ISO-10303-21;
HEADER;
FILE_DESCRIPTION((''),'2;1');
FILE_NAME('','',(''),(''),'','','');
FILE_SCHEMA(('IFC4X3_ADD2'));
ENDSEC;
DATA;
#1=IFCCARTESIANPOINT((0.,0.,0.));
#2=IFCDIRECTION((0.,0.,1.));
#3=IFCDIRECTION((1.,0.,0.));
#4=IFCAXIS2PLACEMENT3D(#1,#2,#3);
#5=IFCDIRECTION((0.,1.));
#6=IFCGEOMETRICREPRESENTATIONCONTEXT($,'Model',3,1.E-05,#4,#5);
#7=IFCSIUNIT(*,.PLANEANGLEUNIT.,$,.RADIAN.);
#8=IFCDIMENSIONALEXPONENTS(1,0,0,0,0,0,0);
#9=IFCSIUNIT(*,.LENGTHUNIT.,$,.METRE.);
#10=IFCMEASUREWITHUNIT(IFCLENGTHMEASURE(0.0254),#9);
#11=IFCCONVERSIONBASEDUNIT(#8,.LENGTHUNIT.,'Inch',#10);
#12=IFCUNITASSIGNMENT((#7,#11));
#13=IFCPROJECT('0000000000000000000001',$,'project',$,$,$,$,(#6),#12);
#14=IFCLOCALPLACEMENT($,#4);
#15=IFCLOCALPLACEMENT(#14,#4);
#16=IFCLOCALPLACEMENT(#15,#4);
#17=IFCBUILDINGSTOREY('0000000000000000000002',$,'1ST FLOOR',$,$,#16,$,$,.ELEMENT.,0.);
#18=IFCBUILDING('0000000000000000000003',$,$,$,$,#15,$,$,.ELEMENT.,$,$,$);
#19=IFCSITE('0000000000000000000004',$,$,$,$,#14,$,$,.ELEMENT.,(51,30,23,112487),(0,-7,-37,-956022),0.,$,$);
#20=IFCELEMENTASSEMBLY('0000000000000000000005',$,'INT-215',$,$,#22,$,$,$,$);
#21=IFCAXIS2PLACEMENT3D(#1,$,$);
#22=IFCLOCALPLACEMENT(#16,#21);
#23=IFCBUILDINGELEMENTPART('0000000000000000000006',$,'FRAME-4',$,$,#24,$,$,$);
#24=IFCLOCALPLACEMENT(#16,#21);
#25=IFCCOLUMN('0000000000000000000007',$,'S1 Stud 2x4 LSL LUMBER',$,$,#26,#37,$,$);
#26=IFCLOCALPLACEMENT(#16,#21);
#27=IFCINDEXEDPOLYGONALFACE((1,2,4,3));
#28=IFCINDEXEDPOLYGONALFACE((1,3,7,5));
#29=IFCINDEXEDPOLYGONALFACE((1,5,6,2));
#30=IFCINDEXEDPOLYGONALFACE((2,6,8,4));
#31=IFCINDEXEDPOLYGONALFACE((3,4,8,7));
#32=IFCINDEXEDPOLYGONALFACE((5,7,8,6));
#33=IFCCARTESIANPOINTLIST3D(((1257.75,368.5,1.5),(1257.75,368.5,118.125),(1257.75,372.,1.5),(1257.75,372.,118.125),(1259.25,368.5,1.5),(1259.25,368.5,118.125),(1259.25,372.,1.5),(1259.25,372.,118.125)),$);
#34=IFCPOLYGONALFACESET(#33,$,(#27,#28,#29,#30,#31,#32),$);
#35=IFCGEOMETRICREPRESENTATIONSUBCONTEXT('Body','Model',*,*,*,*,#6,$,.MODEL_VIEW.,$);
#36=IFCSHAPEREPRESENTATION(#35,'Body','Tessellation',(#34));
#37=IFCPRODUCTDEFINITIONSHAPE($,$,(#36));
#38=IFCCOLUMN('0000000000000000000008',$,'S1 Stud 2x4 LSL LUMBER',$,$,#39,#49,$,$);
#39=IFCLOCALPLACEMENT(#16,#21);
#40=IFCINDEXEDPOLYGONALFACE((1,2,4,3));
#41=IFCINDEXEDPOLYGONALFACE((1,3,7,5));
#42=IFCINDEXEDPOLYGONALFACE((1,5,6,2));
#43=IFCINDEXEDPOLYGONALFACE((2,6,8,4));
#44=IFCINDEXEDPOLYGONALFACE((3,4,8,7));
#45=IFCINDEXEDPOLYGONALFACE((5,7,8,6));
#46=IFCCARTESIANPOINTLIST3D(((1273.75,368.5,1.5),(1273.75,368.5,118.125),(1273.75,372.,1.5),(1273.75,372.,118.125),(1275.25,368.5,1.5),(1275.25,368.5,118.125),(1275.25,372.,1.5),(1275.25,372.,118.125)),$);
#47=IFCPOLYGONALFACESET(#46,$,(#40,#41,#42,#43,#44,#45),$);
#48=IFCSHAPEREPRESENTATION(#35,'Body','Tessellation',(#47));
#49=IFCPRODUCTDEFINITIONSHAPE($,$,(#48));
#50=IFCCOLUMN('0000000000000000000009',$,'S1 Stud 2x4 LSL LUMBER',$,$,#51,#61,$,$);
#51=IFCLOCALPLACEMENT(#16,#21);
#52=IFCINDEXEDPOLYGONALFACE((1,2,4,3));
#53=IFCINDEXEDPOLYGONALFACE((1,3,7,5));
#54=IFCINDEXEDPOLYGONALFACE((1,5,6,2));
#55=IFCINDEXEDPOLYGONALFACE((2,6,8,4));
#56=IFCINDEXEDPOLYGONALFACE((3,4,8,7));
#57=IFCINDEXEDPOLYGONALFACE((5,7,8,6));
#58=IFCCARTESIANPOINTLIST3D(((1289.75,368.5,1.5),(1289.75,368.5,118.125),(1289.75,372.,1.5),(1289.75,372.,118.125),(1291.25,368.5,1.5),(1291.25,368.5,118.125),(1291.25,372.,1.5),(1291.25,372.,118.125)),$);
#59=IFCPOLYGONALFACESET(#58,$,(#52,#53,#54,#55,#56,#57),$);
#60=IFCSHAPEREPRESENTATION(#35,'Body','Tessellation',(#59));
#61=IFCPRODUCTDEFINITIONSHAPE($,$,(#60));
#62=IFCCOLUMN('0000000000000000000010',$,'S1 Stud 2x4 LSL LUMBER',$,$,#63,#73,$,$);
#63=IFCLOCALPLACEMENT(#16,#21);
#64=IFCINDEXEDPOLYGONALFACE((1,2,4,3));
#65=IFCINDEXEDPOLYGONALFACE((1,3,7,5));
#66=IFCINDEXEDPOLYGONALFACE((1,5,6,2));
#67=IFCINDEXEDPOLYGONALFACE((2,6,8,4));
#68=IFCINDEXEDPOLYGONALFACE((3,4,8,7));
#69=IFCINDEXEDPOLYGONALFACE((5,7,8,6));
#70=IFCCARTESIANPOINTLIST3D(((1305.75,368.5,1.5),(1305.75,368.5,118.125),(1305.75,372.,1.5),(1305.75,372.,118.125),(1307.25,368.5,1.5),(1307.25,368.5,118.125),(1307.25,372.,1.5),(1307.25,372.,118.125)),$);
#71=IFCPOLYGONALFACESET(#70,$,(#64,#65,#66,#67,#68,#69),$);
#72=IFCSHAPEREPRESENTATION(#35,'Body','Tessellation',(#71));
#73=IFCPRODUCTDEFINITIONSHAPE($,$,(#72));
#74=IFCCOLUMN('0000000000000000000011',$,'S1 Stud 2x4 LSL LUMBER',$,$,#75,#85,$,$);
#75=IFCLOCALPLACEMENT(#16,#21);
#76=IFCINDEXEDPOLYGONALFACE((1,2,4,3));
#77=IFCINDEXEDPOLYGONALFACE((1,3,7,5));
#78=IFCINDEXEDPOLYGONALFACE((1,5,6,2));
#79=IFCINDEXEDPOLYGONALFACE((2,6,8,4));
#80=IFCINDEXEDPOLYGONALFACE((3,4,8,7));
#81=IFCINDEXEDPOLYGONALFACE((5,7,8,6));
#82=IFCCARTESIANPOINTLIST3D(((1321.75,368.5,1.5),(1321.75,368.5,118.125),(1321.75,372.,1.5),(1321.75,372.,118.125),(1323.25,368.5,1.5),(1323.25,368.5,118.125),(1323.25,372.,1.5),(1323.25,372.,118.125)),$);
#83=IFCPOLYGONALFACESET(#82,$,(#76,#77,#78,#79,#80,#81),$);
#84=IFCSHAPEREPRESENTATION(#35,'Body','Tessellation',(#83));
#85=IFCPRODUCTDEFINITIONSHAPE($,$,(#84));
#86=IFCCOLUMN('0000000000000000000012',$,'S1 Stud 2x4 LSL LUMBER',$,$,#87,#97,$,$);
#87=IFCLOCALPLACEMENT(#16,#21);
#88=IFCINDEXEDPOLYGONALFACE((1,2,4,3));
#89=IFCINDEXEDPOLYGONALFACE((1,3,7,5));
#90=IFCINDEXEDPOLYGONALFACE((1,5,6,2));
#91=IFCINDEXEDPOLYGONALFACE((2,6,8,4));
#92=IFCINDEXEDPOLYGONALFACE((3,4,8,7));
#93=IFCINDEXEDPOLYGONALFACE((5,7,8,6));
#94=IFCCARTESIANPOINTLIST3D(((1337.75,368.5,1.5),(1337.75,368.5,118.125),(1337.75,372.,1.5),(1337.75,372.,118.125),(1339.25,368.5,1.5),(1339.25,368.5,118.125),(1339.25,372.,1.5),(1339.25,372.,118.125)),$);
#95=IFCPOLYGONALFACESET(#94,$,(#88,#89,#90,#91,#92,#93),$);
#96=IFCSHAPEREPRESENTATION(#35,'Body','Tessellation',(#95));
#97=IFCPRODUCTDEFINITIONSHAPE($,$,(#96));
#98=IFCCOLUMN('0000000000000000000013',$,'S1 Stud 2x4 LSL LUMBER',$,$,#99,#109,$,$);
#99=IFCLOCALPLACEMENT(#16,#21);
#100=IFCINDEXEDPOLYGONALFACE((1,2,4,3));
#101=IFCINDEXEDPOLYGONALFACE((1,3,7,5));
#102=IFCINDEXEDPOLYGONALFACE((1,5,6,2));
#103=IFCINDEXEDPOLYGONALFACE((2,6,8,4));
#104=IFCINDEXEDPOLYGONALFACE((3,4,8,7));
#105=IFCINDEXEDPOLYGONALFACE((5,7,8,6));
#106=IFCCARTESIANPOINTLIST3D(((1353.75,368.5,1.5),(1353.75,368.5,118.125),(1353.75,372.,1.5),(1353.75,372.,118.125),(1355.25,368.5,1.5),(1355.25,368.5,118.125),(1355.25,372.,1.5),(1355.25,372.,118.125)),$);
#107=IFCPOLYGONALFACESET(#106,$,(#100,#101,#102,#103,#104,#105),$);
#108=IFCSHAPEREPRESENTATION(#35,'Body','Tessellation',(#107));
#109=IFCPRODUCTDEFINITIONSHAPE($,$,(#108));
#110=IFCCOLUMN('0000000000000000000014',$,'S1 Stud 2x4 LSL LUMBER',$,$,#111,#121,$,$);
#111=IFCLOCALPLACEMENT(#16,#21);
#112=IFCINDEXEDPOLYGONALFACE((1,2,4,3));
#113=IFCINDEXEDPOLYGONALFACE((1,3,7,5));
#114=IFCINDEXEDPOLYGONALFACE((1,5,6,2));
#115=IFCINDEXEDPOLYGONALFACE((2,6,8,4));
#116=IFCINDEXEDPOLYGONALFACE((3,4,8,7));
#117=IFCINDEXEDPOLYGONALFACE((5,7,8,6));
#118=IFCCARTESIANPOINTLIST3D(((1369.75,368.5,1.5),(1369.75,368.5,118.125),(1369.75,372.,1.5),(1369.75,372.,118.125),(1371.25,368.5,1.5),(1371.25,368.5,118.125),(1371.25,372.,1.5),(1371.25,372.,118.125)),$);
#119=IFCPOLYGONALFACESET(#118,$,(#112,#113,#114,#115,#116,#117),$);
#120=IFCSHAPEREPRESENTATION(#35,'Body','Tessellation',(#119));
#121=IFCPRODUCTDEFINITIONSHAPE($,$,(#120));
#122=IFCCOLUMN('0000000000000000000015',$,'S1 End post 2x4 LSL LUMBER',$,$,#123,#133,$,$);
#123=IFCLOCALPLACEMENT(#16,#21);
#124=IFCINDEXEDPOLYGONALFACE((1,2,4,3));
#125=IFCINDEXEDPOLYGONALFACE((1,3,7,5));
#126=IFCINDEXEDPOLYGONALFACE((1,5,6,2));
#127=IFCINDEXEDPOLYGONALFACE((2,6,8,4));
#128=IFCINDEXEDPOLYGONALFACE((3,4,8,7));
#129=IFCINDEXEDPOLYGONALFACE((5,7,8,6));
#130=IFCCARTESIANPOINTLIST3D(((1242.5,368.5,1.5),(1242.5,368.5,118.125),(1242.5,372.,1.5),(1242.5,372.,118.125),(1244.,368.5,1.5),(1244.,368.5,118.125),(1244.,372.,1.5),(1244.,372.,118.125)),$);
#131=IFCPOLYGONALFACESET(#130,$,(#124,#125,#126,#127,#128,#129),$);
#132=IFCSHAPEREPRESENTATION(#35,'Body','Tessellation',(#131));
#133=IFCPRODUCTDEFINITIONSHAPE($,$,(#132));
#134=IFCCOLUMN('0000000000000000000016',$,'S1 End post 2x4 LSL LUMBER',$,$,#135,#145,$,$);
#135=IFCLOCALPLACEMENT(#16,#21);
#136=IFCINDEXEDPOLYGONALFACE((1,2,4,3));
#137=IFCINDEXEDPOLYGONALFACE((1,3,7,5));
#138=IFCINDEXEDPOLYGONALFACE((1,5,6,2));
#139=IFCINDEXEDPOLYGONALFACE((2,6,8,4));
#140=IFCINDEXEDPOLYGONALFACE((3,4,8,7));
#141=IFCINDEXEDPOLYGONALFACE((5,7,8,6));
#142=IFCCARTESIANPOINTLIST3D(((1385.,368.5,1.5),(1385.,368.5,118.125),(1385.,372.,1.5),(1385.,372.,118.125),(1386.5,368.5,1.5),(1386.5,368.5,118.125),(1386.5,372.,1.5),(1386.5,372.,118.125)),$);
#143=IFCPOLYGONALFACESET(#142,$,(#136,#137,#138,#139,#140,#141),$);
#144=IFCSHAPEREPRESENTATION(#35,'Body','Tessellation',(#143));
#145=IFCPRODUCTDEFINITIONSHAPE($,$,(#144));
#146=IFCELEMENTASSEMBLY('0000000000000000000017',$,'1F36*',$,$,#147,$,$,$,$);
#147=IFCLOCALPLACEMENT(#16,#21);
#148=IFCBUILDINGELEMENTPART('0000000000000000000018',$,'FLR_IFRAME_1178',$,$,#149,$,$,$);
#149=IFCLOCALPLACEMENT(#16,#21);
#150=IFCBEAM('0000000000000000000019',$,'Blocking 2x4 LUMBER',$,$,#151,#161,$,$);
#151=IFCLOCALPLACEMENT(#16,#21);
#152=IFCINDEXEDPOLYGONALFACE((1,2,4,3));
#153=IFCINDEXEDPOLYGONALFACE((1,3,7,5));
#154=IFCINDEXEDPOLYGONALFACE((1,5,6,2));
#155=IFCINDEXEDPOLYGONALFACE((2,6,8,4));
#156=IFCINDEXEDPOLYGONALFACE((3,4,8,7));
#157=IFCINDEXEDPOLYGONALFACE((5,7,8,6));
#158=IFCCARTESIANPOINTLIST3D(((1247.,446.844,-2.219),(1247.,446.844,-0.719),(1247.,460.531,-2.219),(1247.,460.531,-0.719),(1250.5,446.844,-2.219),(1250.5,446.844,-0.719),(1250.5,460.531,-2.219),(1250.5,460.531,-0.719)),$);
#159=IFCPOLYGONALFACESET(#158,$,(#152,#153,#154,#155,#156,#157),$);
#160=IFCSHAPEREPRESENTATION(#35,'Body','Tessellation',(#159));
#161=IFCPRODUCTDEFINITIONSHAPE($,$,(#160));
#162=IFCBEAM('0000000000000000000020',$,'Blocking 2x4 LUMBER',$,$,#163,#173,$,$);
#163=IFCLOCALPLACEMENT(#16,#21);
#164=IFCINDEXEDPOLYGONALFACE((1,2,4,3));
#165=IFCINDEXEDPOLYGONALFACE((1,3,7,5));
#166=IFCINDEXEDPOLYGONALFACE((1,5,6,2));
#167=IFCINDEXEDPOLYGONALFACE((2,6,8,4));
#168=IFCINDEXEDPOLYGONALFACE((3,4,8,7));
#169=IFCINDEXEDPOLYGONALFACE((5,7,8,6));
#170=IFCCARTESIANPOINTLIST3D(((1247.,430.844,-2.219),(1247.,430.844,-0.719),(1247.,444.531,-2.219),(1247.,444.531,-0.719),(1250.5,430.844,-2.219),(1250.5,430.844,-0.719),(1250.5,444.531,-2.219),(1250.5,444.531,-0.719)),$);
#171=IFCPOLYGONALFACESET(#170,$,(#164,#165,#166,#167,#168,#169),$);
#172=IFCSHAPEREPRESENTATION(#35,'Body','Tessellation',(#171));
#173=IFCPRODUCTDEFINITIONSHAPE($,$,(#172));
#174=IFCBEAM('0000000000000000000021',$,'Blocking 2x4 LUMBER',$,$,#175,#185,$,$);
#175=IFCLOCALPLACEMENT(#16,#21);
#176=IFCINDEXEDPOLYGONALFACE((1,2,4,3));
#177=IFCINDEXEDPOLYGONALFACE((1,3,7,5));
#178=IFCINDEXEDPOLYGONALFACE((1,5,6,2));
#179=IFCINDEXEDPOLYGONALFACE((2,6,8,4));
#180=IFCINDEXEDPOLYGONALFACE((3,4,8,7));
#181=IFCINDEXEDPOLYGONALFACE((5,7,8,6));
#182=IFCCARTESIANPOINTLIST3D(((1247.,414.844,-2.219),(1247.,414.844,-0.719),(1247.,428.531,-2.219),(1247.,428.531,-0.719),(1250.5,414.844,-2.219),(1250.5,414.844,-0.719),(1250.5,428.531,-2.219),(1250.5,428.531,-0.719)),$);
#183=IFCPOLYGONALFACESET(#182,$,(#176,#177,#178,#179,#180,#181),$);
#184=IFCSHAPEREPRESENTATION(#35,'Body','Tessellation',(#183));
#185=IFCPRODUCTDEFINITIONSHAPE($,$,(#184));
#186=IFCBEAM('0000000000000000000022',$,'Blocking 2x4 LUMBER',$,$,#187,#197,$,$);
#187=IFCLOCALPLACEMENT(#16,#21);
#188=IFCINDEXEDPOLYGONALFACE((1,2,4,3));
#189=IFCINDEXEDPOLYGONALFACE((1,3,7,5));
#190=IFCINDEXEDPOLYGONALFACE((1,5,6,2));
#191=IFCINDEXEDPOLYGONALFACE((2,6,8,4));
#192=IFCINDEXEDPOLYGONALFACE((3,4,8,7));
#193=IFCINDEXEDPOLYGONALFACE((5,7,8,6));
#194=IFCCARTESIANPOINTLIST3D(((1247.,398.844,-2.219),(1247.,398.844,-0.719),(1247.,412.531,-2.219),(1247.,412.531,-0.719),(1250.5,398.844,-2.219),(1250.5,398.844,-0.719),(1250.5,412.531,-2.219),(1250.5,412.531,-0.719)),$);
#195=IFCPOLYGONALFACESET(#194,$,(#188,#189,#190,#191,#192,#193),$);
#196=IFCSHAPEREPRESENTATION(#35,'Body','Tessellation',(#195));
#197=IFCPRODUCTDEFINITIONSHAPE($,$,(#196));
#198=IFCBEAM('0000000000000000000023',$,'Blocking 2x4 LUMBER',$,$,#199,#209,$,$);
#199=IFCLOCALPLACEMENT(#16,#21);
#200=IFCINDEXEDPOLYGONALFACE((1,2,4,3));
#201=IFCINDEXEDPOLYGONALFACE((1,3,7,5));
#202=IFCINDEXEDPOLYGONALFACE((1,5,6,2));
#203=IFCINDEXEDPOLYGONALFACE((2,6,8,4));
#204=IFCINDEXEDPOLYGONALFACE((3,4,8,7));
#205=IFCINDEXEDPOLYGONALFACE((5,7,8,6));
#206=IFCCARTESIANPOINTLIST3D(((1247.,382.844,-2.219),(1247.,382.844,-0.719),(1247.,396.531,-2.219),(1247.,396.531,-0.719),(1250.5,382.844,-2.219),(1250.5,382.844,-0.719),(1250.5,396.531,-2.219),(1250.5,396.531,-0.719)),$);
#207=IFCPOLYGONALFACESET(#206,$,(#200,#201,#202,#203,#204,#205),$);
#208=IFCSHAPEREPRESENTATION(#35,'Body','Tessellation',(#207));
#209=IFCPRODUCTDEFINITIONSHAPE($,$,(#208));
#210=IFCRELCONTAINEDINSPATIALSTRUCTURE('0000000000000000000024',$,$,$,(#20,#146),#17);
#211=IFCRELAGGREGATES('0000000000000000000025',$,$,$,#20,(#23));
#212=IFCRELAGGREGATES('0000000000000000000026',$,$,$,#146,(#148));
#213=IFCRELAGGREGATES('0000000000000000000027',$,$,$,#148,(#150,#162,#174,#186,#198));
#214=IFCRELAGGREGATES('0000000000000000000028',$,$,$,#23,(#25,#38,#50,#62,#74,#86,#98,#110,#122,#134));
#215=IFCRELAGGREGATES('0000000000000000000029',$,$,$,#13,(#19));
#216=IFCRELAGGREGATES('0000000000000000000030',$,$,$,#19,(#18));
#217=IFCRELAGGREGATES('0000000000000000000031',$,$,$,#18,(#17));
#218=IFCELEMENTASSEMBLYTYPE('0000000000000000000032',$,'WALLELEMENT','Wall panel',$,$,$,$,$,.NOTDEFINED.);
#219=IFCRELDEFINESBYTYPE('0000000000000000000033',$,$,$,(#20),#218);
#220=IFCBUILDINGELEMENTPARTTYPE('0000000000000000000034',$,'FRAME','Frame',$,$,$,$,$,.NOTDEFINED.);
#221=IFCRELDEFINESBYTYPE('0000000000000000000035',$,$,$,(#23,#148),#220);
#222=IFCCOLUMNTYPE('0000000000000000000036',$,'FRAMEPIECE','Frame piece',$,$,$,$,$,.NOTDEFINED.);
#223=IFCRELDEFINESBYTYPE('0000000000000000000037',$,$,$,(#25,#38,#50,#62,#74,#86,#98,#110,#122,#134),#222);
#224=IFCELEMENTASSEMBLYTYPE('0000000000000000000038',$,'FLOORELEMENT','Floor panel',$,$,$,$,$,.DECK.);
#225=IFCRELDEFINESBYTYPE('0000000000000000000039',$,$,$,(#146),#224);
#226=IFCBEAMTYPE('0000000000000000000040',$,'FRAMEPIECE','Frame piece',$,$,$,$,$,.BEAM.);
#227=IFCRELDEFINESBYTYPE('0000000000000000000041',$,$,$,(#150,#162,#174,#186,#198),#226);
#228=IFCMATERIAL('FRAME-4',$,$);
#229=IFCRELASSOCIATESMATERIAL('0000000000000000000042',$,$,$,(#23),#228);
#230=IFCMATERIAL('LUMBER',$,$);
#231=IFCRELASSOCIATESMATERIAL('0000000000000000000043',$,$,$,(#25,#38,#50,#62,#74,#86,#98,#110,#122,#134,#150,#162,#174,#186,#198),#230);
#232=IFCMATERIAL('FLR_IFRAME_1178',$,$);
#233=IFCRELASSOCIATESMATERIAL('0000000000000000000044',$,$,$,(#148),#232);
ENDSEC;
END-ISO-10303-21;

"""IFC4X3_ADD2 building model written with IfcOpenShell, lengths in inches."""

from ifc_helpers import new_model, entity, si_unit, converted_unit, direction, frame, origin_with_axes, origin_2d_with_axis, place, context, subcontext, project, spatial, rectangle, extrude, material, type_object, element, aggregate, save


model = new_model("IFC4X3_ADD2")

# Units and contexts
model_context = context("Model", 3, precision=1e-05, world=origin_with_axes(), true_north=direction((0.0, 1.0)))
body_context = subcontext(model_context, "Body", "Model", "MODEL_VIEW")
ifc_project = project(units=[si_unit("PLANEANGLEUNIT", "RADIAN"), converted_unit("LENGTHUNIT", "Inch", entity("IfcLengthMeasure", 0.0254), si_unit("LENGTHUNIT", "METRE"), dimensions=[1, 0, 0, 0, 0, 0, 0])], contexts=[model_context])

# Site, building, storey
site_placement = place(None, origin_with_axes())
site = spatial("IfcSite", under=ifc_project, at=site_placement, CompositionType="ELEMENT", RefLatitude=(51, 30, 23, 112487), RefLongitude=(0, -7, -37, -956022), RefElevation=0.0)
building_placement = place(site_placement, origin_with_axes())
building = spatial("IfcBuilding", under=site, at=building_placement, CompositionType="ELEMENT")
storey_placement = place(building_placement, origin_with_axes())
storey = spatial("IfcBuildingStorey", under=building, at=storey_placement, Name="1ST FLOOR", CompositionType="ELEMENT", Elevation=0.0)

# Element assembly, building element part, columns
element_assembly_type_1 = type_object("IfcElementAssemblyType", Name="WALLELEMENT", Description="Wall panel", PredefinedType="NOTDEFINED")
assembly_1_placement = place(storey_placement, origin_with_axes())
assembly_1 = element("IfcElementAssembly", 1, at=assembly_1_placement, inside=storey, type_object=element_assembly_type_1, Name="INT-215")
ifc_material_1 = material(Name="FRAME-4")
building_element_part_type = type_object("IfcBuildingElementPartType", Name="FRAME", Description="Frame", PredefinedType="NOTDEFINED")
building_element_part_1_placement = place(storey_placement, origin_with_axes())
building_element_part_1 = element("IfcBuildingElementPart", 2, at=building_element_part_1_placement, type_object=building_element_part_type, material=ifc_material_1, Name="FRAME-4")
aggregate(assembly_1, [building_element_part_1])
ifc_material_2 = material(Name="LUMBER")
column_type = type_object("IfcColumnType", Name="FRAMEPIECE", Description="Frame piece", PredefinedType="NOTDEFINED")
column_1_placement = place(storey_placement, frame((1258.5, 370.25, 118.125), z_axis=(0.0, 0.0, -1.0), x_axis=(-1.0, 0.0, 0.0)))
column_1 = element("IfcColumn", 3, at=column_1_placement, type_object=column_type, material=ifc_material_2, Name="S1 Stud 2x4 LSL LUMBER", context=body_context, shape_type="SweptSolid", body=[
    extrude(rectangle(XDim=1.5, YDim=3.5, at=origin_2d_with_axis()), origin_with_axes(), (0.0, 0.0, 1.0), 116.625),
])
column_2_placement = place(storey_placement, frame((1274.5, 370.25, 118.125), z_axis=(0.0, 0.0, -1.0), x_axis=(-1.0, 0.0, 0.0)))
column_2 = element("IfcColumn", 4, at=column_2_placement, type_object=column_type, material=ifc_material_2, Name="S1 Stud 2x4 LSL LUMBER", context=body_context, shape_type="SweptSolid", body=[
    extrude(rectangle(XDim=1.5, YDim=3.5, at=origin_2d_with_axis()), origin_with_axes(), (0.0, 0.0, 1.0), 116.625),
])
column_3_placement = place(storey_placement, frame((1290.5, 370.25, 118.125), z_axis=(0.0, 0.0, -1.0), x_axis=(-1.0, 0.0, 0.0)))
column_3 = element("IfcColumn", 5, at=column_3_placement, type_object=column_type, material=ifc_material_2, Name="S1 Stud 2x4 LSL LUMBER", context=body_context, shape_type="SweptSolid", body=[
    extrude(rectangle(XDim=1.5, YDim=3.5, at=origin_2d_with_axis()), origin_with_axes(), (0.0, 0.0, 1.0), 116.625),
])
column_4_placement = place(storey_placement, frame((1306.5, 370.25, 118.125), z_axis=(0.0, 0.0, -1.0), x_axis=(-1.0, 0.0, 0.0)))
column_4 = element("IfcColumn", 6, at=column_4_placement, type_object=column_type, material=ifc_material_2, Name="S1 Stud 2x4 LSL LUMBER", context=body_context, shape_type="SweptSolid", body=[
    extrude(rectangle(XDim=1.5, YDim=3.5, at=origin_2d_with_axis()), origin_with_axes(), (0.0, 0.0, 1.0), 116.625),
])
column_5_placement = place(storey_placement, frame((1322.5, 370.25, 118.125), z_axis=(0.0, 0.0, -1.0), x_axis=(-1.0, 0.0, 0.0)))
column_5 = element("IfcColumn", 7, at=column_5_placement, type_object=column_type, material=ifc_material_2, Name="S1 Stud 2x4 LSL LUMBER", context=body_context, shape_type="SweptSolid", body=[
    extrude(rectangle(XDim=1.5, YDim=3.5, at=origin_2d_with_axis()), origin_with_axes(), (0.0, 0.0, 1.0), 116.625),
])
column_6_placement = place(storey_placement, frame((1338.5, 370.25, 118.125), z_axis=(0.0, 0.0, -1.0), x_axis=(-1.0, 0.0, 0.0)))
column_6 = element("IfcColumn", 8, at=column_6_placement, type_object=column_type, material=ifc_material_2, Name="S1 Stud 2x4 LSL LUMBER", context=body_context, shape_type="SweptSolid", body=[
    extrude(rectangle(XDim=1.5, YDim=3.5, at=origin_2d_with_axis()), origin_with_axes(), (0.0, 0.0, 1.0), 116.625),
])
column_7_placement = place(storey_placement, frame((1354.5, 370.25, 118.125), z_axis=(0.0, 0.0, -1.0), x_axis=(-1.0, 0.0, 0.0)))
column_7 = element("IfcColumn", 9, at=column_7_placement, type_object=column_type, material=ifc_material_2, Name="S1 Stud 2x4 LSL LUMBER", context=body_context, shape_type="SweptSolid", body=[
    extrude(rectangle(XDim=1.5, YDim=3.5, at=origin_2d_with_axis()), origin_with_axes(), (0.0, 0.0, 1.0), 116.625),
])
column_8_placement = place(storey_placement, frame((1370.5, 370.25, 118.125), z_axis=(0.0, 0.0, -1.0), x_axis=(-1.0, 0.0, 0.0)))
column_8 = element("IfcColumn", 10, at=column_8_placement, type_object=column_type, material=ifc_material_2, Name="S1 Stud 2x4 LSL LUMBER", context=body_context, shape_type="SweptSolid", body=[
    extrude(rectangle(XDim=1.5, YDim=3.5, at=origin_2d_with_axis()), origin_with_axes(), (0.0, 0.0, 1.0), 116.625),
])
column_9_placement = place(storey_placement, frame((1243.25, 370.25, 1.5), z_axis=(0.0, 0.0, 1.0), x_axis=(1.0, 0.0, 0.0)))
column_9 = element("IfcColumn", 11, at=column_9_placement, type_object=column_type, material=ifc_material_2, Name="S1 End post 2x4 LSL LUMBER", context=body_context, shape_type="SweptSolid", body=[
    extrude(rectangle(XDim=1.5, YDim=3.5, at=origin_2d_with_axis()), origin_with_axes(), (0.0, 0.0, 1.0), 116.625),
])
column_10_placement = place(storey_placement, frame((1385.75, 370.25, 118.125), z_axis=(0.0, 0.0, -1.0), x_axis=(-1.0, 0.0, 0.0)))
column_10 = element("IfcColumn", 12, at=column_10_placement, type_object=column_type, material=ifc_material_2, Name="S1 End post 2x4 LSL LUMBER", context=body_context, shape_type="SweptSolid", body=[
    extrude(rectangle(XDim=1.5, YDim=3.5, at=origin_2d_with_axis()), origin_with_axes(), (0.0, 0.0, 1.0), 116.625),
])

# Element assembly, building element part, beams
element_assembly_type_2 = type_object("IfcElementAssemblyType", Name="FLOORELEMENT", Description="Floor panel", PredefinedType="DECK")
assembly_2_placement = place(storey_placement, origin_with_axes())
assembly_2 = element("IfcElementAssembly", 13, at=assembly_2_placement, inside=storey, type_object=element_assembly_type_2, Name="1F36*")
ifc_material_3 = material(Name="FLR_IFRAME_1178")
building_element_part_2_placement = place(storey_placement, origin_with_axes())
building_element_part_2 = element("IfcBuildingElementPart", 14, at=building_element_part_2_placement, type_object=building_element_part_type, material=ifc_material_3, Name="FLR_IFRAME_1178")
aggregate(assembly_2, [building_element_part_2])
beam_type_1 = type_object("IfcBeamType", Name="FRAMEPIECE", Description="Frame piece", PredefinedType="BEAM")
beam_1_placement = place(storey_placement, frame((1248.75, 460.531, -1.469), z_axis=(0.0, -1.0, 0.0), x_axis=(0.0, 0.0, 1.0)))
beam_1 = element("IfcBeam", 15, at=beam_1_placement, type_object=beam_type_1, material=ifc_material_2, Name="Blocking 2x4 LUMBER", context=body_context, shape_type="SweptSolid", body=[
    extrude(rectangle(XDim=1.5, YDim=3.5, at=origin_2d_with_axis()), origin_with_axes(), (0.0, 0.0, 1.0), 13.688),
])
beam_2_placement = place(storey_placement, frame((1248.75, 444.531, -1.469), z_axis=(0.0, -1.0, 0.0), x_axis=(0.0, 0.0, 1.0)))
beam_2 = element("IfcBeam", 16, at=beam_2_placement, type_object=beam_type_1, material=ifc_material_2, Name="Blocking 2x4 LUMBER", context=body_context, shape_type="SweptSolid", body=[
    extrude(rectangle(XDim=1.5, YDim=3.5, at=origin_2d_with_axis()), origin_with_axes(), (0.0, 0.0, 1.0), 13.688),
])
beam_3_placement = place(storey_placement, frame((1248.75, 428.531, -1.469), z_axis=(0.0, -1.0, 0.0), x_axis=(0.0, 0.0, 1.0)))
beam_3 = element("IfcBeam", 17, at=beam_3_placement, type_object=beam_type_1, material=ifc_material_2, Name="Blocking 2x4 LUMBER", context=body_context, shape_type="SweptSolid", body=[
    extrude(rectangle(XDim=1.5, YDim=3.5, at=origin_2d_with_axis()), origin_with_axes(), (0.0, 0.0, 1.0), 13.688),
])
beam_4_placement = place(storey_placement, frame((1248.75, 412.531, -1.469), z_axis=(0.0, -1.0, 0.0), x_axis=(0.0, 0.0, 1.0)))
beam_4 = element("IfcBeam", 18, at=beam_4_placement, type_object=beam_type_1, material=ifc_material_2, Name="Blocking 2x4 LUMBER", context=body_context, shape_type="SweptSolid", body=[
    extrude(rectangle(XDim=1.5, YDim=3.5, at=origin_2d_with_axis()), origin_with_axes(), (0.0, 0.0, 1.0), 13.688),
])
beam_5_placement = place(storey_placement, frame((1248.75, 396.531, -1.469), z_axis=(0.0, -1.0, 0.0), x_axis=(0.0, 0.0, 1.0)))
beam_5 = element("IfcBeam", 19, at=beam_5_placement, type_object=beam_type_1, material=ifc_material_2, Name="Blocking 2x4 LUMBER", context=body_context, shape_type="SweptSolid", body=[
    extrude(rectangle(XDim=1.5, YDim=3.5, at=origin_2d_with_axis()), origin_with_axes(), (0.0, 0.0, 1.0), 13.688),
])
aggregate(building_element_part_2, [beam_1, beam_2, beam_3, beam_4, beam_5])

aggregate(building_element_part_1, [column_1, column_2, column_3, column_4, column_5, column_6, column_7, column_8, column_9, column_10])

save(model, "model.ifc")
